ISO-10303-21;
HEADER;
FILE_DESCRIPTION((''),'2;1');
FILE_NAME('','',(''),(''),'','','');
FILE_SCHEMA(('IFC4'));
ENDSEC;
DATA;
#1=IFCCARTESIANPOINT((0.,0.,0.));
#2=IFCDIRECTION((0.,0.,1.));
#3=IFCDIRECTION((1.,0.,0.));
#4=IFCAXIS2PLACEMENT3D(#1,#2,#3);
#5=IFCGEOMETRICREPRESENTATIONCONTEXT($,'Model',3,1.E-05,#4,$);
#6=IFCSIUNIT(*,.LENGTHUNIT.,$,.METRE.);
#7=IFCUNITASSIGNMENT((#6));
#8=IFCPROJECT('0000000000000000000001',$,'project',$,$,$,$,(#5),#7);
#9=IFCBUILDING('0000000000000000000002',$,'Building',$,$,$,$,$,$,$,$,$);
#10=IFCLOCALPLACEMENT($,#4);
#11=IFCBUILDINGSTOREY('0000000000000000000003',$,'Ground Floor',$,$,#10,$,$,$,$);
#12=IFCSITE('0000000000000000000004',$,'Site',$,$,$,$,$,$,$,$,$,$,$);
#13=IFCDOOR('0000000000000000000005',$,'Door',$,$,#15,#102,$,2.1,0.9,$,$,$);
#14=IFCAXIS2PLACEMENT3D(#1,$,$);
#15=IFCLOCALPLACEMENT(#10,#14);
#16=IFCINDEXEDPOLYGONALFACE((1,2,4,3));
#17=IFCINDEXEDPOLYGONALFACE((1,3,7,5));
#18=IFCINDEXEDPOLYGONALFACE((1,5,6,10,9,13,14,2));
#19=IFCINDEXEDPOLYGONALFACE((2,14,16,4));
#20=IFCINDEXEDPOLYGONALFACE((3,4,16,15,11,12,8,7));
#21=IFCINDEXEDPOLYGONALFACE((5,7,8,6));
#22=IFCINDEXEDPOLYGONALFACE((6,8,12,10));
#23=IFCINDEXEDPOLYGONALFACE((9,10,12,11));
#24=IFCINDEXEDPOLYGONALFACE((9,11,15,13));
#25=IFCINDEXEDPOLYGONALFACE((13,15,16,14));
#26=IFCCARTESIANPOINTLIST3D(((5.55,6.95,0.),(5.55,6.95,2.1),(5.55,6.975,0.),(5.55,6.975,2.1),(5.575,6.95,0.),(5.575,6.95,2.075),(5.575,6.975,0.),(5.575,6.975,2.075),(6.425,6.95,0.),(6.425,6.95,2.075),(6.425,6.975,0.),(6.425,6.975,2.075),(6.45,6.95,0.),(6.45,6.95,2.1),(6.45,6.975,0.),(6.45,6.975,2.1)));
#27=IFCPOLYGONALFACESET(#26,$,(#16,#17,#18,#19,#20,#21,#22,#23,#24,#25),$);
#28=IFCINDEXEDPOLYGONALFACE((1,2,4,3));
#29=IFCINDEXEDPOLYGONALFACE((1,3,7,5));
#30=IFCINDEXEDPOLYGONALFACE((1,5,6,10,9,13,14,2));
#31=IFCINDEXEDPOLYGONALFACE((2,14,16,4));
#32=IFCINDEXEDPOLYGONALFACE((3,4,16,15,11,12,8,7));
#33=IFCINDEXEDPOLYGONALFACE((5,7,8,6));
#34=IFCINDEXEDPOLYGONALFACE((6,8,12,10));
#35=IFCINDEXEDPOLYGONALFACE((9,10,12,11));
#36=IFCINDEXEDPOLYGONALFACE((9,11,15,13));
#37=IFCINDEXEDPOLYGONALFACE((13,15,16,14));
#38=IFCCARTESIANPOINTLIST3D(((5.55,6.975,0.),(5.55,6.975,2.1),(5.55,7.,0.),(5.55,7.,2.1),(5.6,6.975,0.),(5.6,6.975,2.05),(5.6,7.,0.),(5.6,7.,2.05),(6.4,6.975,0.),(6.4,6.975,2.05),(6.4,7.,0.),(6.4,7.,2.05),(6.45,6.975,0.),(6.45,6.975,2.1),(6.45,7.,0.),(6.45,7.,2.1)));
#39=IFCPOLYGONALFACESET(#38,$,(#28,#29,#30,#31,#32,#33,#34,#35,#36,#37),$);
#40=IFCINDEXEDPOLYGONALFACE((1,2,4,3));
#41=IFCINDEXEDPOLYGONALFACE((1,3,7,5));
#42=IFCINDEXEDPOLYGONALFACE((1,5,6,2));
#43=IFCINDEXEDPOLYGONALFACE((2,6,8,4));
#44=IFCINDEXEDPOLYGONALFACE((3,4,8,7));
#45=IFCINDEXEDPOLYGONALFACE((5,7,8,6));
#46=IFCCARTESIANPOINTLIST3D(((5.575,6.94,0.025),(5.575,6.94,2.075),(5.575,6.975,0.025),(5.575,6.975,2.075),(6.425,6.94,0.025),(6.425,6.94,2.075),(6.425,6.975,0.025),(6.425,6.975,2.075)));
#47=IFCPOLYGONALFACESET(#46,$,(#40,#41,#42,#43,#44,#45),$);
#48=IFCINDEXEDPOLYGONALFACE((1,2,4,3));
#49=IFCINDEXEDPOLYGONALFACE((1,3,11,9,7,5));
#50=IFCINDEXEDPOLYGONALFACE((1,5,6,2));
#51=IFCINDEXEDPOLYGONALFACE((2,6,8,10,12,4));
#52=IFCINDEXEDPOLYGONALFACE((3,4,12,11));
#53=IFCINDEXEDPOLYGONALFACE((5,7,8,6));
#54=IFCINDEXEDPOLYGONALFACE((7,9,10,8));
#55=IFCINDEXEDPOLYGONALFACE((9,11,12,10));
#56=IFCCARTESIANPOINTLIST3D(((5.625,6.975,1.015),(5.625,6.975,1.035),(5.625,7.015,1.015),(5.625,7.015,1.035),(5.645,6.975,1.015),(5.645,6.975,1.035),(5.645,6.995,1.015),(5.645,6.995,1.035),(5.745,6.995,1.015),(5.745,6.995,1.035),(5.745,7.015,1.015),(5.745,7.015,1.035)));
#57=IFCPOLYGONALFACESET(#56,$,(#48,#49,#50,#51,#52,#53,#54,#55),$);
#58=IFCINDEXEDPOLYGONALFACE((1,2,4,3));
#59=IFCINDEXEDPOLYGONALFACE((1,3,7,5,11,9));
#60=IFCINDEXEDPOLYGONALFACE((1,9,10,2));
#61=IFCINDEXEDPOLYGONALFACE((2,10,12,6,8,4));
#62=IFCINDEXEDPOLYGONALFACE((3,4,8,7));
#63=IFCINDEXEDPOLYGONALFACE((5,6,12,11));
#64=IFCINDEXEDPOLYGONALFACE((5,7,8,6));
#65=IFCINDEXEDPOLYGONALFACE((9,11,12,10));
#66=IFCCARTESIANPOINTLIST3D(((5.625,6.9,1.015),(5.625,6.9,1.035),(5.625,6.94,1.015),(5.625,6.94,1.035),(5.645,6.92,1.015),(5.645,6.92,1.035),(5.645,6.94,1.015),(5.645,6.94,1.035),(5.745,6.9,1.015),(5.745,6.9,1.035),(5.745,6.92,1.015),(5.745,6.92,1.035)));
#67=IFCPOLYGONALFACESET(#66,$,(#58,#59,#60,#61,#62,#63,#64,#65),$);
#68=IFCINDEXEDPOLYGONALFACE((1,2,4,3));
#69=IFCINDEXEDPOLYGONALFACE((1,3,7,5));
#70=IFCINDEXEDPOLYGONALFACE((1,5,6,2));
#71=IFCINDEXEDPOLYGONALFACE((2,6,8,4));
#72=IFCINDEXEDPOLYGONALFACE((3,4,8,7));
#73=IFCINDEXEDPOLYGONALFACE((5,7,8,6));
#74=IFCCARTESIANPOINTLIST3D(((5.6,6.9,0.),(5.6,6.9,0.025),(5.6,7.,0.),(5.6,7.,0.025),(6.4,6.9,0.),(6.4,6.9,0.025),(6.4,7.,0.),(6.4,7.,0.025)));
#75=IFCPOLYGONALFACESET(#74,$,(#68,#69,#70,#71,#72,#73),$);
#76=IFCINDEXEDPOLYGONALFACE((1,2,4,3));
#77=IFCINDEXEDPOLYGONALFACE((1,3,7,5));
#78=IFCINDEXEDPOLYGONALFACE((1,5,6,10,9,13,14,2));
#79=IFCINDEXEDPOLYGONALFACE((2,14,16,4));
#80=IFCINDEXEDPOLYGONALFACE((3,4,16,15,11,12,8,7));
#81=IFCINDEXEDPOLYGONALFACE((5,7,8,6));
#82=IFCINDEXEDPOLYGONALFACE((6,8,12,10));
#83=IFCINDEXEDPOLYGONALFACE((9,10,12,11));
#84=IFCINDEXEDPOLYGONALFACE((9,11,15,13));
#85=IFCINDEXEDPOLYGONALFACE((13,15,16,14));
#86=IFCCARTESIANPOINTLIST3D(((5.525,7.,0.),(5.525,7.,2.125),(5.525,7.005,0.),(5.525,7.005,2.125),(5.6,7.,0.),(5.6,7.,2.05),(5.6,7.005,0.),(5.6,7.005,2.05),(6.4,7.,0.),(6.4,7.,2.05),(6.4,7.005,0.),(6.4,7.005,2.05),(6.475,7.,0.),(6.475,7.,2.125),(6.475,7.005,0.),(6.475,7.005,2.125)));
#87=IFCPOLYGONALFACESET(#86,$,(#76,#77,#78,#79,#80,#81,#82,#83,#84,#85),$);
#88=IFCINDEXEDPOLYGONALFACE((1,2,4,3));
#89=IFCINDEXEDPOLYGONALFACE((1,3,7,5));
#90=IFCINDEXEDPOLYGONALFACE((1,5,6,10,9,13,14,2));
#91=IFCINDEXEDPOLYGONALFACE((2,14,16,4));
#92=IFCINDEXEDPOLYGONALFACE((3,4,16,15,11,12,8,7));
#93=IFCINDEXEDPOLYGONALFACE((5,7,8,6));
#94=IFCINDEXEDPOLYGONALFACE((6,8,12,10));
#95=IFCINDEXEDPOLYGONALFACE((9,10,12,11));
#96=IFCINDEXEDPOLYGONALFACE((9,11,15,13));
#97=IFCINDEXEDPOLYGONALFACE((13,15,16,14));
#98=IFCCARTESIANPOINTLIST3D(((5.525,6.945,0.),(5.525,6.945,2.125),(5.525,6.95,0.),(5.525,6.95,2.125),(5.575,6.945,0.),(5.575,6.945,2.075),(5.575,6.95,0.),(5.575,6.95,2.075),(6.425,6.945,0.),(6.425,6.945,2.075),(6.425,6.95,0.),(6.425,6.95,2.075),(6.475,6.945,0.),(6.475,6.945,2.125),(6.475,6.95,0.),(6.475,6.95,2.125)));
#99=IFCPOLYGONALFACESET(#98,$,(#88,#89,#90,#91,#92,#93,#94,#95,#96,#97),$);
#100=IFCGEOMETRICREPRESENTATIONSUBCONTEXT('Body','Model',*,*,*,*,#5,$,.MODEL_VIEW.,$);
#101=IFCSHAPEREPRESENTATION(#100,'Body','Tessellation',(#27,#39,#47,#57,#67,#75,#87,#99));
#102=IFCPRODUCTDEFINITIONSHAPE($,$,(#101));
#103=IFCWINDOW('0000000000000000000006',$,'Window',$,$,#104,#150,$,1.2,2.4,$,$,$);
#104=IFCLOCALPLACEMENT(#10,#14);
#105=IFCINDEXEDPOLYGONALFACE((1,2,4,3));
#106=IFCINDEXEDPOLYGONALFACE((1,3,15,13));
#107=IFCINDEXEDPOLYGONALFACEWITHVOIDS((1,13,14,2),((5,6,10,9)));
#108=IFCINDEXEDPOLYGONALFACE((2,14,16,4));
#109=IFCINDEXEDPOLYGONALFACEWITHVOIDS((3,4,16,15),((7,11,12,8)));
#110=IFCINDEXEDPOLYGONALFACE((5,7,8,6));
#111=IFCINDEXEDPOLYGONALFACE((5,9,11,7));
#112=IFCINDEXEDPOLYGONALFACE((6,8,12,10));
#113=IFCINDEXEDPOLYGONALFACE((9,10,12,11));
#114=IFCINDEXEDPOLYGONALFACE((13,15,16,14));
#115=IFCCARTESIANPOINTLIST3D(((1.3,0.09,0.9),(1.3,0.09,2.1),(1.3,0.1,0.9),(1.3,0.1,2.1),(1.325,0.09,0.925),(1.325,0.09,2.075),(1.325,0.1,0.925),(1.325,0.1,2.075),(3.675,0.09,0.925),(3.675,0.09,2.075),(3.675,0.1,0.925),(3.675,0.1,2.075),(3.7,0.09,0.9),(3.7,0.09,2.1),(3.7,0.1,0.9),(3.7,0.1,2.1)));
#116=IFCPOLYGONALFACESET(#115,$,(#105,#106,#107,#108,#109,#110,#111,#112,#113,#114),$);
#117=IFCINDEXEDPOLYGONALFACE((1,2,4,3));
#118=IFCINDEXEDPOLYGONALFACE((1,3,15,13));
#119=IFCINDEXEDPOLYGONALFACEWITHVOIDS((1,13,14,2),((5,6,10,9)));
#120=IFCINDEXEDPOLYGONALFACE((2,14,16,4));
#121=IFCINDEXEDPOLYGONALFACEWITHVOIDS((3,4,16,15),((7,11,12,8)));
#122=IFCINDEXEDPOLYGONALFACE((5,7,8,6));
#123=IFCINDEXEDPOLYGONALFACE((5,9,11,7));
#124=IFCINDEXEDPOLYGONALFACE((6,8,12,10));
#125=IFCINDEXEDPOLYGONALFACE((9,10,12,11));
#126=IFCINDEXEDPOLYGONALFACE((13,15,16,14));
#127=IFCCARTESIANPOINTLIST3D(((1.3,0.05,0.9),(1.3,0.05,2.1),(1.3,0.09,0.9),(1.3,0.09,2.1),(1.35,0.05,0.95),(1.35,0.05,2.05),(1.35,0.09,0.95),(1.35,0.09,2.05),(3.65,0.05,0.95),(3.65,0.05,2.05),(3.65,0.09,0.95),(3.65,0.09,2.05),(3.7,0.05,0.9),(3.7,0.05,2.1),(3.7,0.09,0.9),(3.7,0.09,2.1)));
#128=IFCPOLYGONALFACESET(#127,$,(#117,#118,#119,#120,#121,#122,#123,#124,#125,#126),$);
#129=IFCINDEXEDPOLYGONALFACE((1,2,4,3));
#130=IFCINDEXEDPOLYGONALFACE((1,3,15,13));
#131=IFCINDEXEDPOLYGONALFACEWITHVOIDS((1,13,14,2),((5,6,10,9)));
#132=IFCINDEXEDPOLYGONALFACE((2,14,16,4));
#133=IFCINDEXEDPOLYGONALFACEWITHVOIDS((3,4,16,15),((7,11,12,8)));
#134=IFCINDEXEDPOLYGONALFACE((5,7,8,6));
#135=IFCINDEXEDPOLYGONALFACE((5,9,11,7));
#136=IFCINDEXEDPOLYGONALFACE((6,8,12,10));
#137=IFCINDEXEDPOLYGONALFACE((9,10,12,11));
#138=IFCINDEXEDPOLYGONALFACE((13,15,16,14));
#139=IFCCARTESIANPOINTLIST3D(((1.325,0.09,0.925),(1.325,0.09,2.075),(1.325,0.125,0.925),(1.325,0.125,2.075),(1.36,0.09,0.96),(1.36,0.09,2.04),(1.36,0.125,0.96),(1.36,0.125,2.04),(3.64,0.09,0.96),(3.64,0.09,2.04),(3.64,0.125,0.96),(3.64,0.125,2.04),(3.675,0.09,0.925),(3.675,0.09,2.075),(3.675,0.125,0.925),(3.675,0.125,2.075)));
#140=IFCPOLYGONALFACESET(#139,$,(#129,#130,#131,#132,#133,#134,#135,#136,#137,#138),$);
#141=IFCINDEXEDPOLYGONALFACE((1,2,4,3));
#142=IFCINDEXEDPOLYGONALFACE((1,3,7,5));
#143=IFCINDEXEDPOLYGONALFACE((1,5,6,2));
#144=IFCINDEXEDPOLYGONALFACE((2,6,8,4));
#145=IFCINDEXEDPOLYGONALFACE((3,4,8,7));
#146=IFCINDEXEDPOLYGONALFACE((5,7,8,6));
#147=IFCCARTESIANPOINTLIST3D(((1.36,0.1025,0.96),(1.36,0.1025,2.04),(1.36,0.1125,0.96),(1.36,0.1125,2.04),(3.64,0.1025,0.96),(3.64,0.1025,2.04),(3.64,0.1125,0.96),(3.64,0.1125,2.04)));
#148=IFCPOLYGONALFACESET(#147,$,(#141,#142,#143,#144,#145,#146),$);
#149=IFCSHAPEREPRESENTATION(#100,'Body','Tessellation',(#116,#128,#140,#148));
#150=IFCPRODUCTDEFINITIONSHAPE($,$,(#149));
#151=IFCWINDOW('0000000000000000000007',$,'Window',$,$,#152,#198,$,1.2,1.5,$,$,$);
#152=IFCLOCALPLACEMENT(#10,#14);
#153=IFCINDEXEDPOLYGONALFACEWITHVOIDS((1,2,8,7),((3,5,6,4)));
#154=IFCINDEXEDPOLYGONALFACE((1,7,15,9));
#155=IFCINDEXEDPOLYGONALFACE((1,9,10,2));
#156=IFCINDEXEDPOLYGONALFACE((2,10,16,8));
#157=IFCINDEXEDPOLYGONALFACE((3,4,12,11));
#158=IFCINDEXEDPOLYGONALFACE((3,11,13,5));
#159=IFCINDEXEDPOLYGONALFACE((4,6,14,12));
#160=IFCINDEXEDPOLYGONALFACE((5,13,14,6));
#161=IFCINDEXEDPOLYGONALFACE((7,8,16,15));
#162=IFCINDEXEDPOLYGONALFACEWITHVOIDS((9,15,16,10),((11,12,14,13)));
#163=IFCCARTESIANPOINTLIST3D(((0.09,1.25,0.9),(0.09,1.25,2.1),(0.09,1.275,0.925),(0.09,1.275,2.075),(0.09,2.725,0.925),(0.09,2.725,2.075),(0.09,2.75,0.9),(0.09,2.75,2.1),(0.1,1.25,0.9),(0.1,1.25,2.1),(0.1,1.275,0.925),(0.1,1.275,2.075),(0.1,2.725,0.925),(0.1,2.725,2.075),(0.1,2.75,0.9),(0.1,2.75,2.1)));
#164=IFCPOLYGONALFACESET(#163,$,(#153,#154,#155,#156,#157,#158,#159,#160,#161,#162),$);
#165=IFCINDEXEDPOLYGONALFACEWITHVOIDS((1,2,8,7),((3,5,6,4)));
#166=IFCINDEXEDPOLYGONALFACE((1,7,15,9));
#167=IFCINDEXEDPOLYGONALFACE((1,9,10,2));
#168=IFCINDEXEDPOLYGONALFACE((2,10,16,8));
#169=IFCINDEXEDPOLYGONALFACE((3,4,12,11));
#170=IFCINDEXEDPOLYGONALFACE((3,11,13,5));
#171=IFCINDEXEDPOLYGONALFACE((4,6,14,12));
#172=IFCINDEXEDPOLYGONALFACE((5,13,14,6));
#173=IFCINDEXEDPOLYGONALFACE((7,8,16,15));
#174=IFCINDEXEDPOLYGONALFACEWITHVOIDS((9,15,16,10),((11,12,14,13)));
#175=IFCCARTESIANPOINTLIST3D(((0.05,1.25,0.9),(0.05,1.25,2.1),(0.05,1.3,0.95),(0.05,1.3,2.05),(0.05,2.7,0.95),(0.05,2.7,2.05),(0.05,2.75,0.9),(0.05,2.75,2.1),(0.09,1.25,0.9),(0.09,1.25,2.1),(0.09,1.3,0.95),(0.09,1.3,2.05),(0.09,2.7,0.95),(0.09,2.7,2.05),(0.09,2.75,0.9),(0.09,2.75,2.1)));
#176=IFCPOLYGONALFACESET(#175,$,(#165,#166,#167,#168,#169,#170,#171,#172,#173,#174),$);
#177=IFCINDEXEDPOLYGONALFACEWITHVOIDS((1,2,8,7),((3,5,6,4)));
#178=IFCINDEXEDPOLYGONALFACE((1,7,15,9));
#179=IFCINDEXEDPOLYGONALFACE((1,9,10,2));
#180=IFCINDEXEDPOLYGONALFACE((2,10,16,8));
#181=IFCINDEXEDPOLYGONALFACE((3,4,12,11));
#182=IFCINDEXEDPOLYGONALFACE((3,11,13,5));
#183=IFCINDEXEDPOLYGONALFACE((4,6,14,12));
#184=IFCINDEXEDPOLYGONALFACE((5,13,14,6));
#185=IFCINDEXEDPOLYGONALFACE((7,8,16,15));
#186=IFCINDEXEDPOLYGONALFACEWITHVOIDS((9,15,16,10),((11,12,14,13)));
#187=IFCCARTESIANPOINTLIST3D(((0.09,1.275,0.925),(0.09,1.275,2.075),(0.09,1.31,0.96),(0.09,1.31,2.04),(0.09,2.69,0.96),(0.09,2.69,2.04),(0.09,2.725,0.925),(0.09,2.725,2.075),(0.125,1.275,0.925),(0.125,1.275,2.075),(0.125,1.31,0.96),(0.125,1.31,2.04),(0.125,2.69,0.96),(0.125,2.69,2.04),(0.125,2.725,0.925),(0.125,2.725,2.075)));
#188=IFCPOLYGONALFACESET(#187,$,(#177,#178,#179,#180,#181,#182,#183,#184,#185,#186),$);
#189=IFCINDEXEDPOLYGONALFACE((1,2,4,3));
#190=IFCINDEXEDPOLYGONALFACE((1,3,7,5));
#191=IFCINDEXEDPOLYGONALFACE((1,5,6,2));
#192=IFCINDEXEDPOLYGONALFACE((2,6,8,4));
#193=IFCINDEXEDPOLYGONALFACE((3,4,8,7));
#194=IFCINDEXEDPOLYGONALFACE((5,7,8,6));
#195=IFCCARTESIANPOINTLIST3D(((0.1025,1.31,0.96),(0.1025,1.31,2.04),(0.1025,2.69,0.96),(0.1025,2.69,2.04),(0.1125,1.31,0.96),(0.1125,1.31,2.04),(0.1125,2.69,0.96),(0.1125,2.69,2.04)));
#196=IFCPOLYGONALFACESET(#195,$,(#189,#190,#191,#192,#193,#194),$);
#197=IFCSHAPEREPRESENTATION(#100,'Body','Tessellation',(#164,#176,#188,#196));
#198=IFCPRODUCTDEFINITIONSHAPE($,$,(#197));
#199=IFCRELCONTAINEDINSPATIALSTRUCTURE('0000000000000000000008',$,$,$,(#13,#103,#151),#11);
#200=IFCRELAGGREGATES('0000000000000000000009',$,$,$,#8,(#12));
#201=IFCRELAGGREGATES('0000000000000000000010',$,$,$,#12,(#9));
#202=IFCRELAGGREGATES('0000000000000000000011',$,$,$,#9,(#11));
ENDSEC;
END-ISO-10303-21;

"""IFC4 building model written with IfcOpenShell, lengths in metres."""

from ifc_helpers import new_model, si_unit, frame, origin_with_axes, place, context, subcontext, project, spatial, line, indexed_curve, outline, extrude, element, save


model = new_model("IFC4")

# Units and contexts
model_context = context("Model", 3, precision=1e-05, world=origin_with_axes())
body_context = subcontext(model_context, "Body", "Model", "MODEL_VIEW")
ifc_project = project(units=[si_unit("LENGTHUNIT", "METRE")], contexts=[model_context])

# Site, building, storey
site = spatial("IfcSite", under=ifc_project, Name="Site")
building = spatial("IfcBuilding", under=site, Name="Building")
storey_placement = place(None, origin_with_axes())
storey = spatial("IfcBuildingStorey", under=building, at=storey_placement, Name="Ground Floor")

# Door
door_1_placement = place(storey_placement, frame((6.45, 7.0, 0.0), z_axis=(0.0, 0.0, 1.0), x_axis=(-1.0, 0.0, 0.0)))
element("IfcDoor", 1, at=door_1_placement, inside=storey, Name="Door", OverallHeight=2.1, OverallWidth=0.9, context=body_context, shape_type="SweptSolid", body=[
    extrude(outline(indexed_curve([(0.0, 0.0), (0.0, 2.1), (0.9, 2.1), (0.9, 0.0), (0.875, 0.0), (0.875, 2.075), (0.025, 2.075), (0.025, 0.0)], segments=[line(1, 2, 3, 4, 5, 6, 7, 8, 1)])), frame((0.0, 0.025, 0.0), z_axis=(0.0, -1.0, 0.0), x_axis=(1.0, 0.0, 0.0)), (0.0, 0.0, -1.0), 0.025),
    extrude(outline(indexed_curve([(0.0, 0.0), (0.0, 2.1), (0.9, 2.1), (0.9, 0.0), (0.85, 0.0), (0.85, 2.05), (0.05, 2.05), (0.05, 0.0)], segments=[line(1, 2, 3, 4, 5, 6, 7, 8, 1)])), frame((0.0, 0.0, 0.0), z_axis=(0.0, -1.0, 0.0), x_axis=(1.0, 0.0, 0.0)), (0.0, 0.0, -1.0), 0.025),
    extrude(outline(indexed_curve([(0.0, 0.0), (0.85, 0.0), (0.85, 0.035), (0.0, 0.035)], segments=[line(1, 2, 3, 4, 1)])), frame((0.025, 0.025, 0.025), z_axis=(0.0, 0.0, 1.0), x_axis=(1.0, 0.0, 0.0)), (0.0, 0.0, 1.0), 2.05),
    extrude(outline(indexed_curve([(0.0, 0.0), (0.0, -0.04), (-0.12, -0.04), (-0.12, -0.02), (-0.02, -0.02), (-0.02, 0.0)], segments=[line(1, 2, 3, 4, 5, 6, 1)])), frame((0.825, 0.025, 1.015), z_axis=(0.0, 0.0, 1.0), x_axis=(1.0, 0.0, 0.0)), (0.0, 0.0, 1.0), 0.02),
    extrude(outline(indexed_curve([(0.0, 0.0), (0.0, 0.04), (-0.12, 0.04), (-0.12, 0.02), (-0.02, 0.02), (-0.02, 0.0)], segments=[line(1, 2, 3, 4, 5, 6, 1)])), frame((0.825, 0.06, 1.015), z_axis=(0.0, 0.0, 1.0), x_axis=(1.0, 0.0, 0.0)), (0.0, 0.0, 1.0), 0.02),
    extrude(outline(indexed_curve([(0.0, 0.0), (0.8, 0.0), (0.8, 0.1), (0.0, 0.1)], segments=[line(1, 2, 3, 4, 1)])), frame((0.05, 0.0, 0.0), z_axis=(0.0, 0.0, 1.0), x_axis=(1.0, 0.0, 0.0)), (0.0, 0.0, 1.0), 0.025),
    extrude(outline(indexed_curve([(0.0, 0.0), (0.0, 2.125), (0.95, 2.125), (0.95, 0.0), (0.875, 0.0), (0.875, 2.05), (0.075, 2.05), (0.075, 0.0)], segments=[line(1, 2, 3, 4, 5, 6, 7, 8, 1)])), frame((-0.025, -0.005, 0.0), z_axis=(0.0, -1.0, 0.0), x_axis=(1.0, 0.0, 0.0)), (0.0, 0.0, -1.0), 0.005),
    extrude(outline(indexed_curve([(0.0, 0.0), (0.0, 2.125), (0.95, 2.125), (0.95, 0.0), (0.9, 0.0), (0.9, 2.075), (0.05, 2.075), (0.05, 0.0)], segments=[line(1, 2, 3, 4, 5, 6, 7, 8, 1)])), frame((-0.025, 0.05, 0.0), z_axis=(0.0, -1.0, 0.0), x_axis=(1.0, 0.0, 0.0)), (0.0, 0.0, -1.0), 0.005),
])

# Windows
window_1_placement = place(storey_placement, frame((1.3, 0.0, 0.9), z_axis=(0.0, 0.0, 1.0), x_axis=(1.0, 0.0, 0.0)))
element("IfcWindow", 2, at=window_1_placement, inside=storey, Name="Window", OverallHeight=1.2, OverallWidth=2.4, context=body_context, shape_type="SweptSolid", body=[
    extrude(outline(indexed_curve([(0.0, 0.0), (2.4, 0.0), (2.4, 1.2), (0.0, 1.2)], segments=[line(1, 2, 3, 4, 1)]), holes=[indexed_curve([(0.025, 0.025), (2.375, 0.025), (2.375, 1.175), (0.025, 1.175)], segments=[line(1, 2, 3, 4, 1)])]), frame((0.0, 0.09, 0.0), z_axis=(0.0, -1.0, 0.0), x_axis=(1.0, 0.0, 0.0)), (0.0, 0.0, -1.0), 0.01),
    extrude(outline(indexed_curve([(0.0, 0.0), (2.4, 0.0), (2.4, 1.2), (0.0, 1.2)], segments=[line(1, 2, 3, 4, 1)]), holes=[indexed_curve([(0.05, 0.05), (2.35, 0.05), (2.35, 1.15), (0.05, 1.15)], segments=[line(1, 2, 3, 4, 1)])]), frame((0.0, 0.05, 0.0), z_axis=(0.0, -1.0, 0.0), x_axis=(1.0, 0.0, 0.0)), (0.0, 0.0, -1.0), 0.04),
    extrude(outline(indexed_curve([(0.0, 0.0), (2.35, 0.0), (2.35, 1.15), (0.0, 1.15)], segments=[line(1, 2, 3, 4, 1)]), holes=[indexed_curve([(0.035, 0.035), (2.315, 0.035), (2.315, 1.115), (0.035, 1.115)], segments=[line(1, 2, 3, 4, 1)])]), frame((0.025, 0.09, 0.025), z_axis=(0.0, -1.0, 0.0), x_axis=(1.0, 0.0, 0.0)), (0.0, 0.0, -1.0), 0.035),
    extrude(outline(indexed_curve([(0.035, 0.035), (2.315, 0.035), (2.315, 1.115), (0.035, 1.115)], segments=[line(1, 2, 3, 4, 1)])), frame((0.025, 0.1025, 0.025), z_axis=(0.0, -1.0, 0.0), x_axis=(1.0, 0.0, 0.0)), (0.0, 0.0, -1.0), 0.01),
])
for number, where, z_axis, x_axis, name in (
    (3, (0.0, 2.75, 0.9), (0.0, 0.0, 1.0), (0.0, -1.0, 0.0), "Window"),
):
    element("IfcWindow", number, at=place(storey_placement, frame(where, z_axis=z_axis, x_axis=x_axis)), inside=storey, Name=name, OverallHeight=1.2, OverallWidth=1.5, context=body_context, shape_type="SweptSolid", body=[
        extrude(outline(indexed_curve([(0.0, 0.0), (1.5, 0.0), (1.5, 1.2), (0.0, 1.2)], segments=[line(1, 2, 3, 4, 1)]), holes=[indexed_curve([(0.025, 0.025), (1.475, 0.025), (1.475, 1.175), (0.025, 1.175)], segments=[line(1, 2, 3, 4, 1)])]), frame((0.0, 0.09, 0.0), z_axis=(0.0, -1.0, 0.0), x_axis=(1.0, 0.0, 0.0)), (0.0, 0.0, -1.0), 0.01),
        extrude(outline(indexed_curve([(0.0, 0.0), (1.5, 0.0), (1.5, 1.2), (0.0, 1.2)], segments=[line(1, 2, 3, 4, 1)]), holes=[indexed_curve([(0.05, 0.05), (1.45, 0.05), (1.45, 1.15), (0.05, 1.15)], segments=[line(1, 2, 3, 4, 1)])]), frame((0.0, 0.05, 0.0), z_axis=(0.0, -1.0, 0.0), x_axis=(1.0, 0.0, 0.0)), (0.0, 0.0, -1.0), 0.04),
        extrude(outline(indexed_curve([(0.0, 0.0), (1.45, 0.0), (1.45, 1.15), (0.0, 1.15)], segments=[line(1, 2, 3, 4, 1)]), holes=[indexed_curve([(0.035, 0.035), (1.415, 0.035), (1.415, 1.115), (0.035, 1.115)], segments=[line(1, 2, 3, 4, 1)])]), frame((0.025, 0.09, 0.025), z_axis=(0.0, -1.0, 0.0), x_axis=(1.0, 0.0, 0.0)), (0.0, 0.0, -1.0), 0.035),
        extrude(outline(indexed_curve([(0.035, 0.035), (1.415, 0.035), (1.415, 1.115), (0.035, 1.115)], segments=[line(1, 2, 3, 4, 1)])), frame((0.025, 0.1025, 0.025), z_axis=(0.0, -1.0, 0.0), x_axis=(1.0, 0.0, 0.0)), (0.0, 0.0, -1.0), 0.01),
    ])

save(model, "model.ifc")
